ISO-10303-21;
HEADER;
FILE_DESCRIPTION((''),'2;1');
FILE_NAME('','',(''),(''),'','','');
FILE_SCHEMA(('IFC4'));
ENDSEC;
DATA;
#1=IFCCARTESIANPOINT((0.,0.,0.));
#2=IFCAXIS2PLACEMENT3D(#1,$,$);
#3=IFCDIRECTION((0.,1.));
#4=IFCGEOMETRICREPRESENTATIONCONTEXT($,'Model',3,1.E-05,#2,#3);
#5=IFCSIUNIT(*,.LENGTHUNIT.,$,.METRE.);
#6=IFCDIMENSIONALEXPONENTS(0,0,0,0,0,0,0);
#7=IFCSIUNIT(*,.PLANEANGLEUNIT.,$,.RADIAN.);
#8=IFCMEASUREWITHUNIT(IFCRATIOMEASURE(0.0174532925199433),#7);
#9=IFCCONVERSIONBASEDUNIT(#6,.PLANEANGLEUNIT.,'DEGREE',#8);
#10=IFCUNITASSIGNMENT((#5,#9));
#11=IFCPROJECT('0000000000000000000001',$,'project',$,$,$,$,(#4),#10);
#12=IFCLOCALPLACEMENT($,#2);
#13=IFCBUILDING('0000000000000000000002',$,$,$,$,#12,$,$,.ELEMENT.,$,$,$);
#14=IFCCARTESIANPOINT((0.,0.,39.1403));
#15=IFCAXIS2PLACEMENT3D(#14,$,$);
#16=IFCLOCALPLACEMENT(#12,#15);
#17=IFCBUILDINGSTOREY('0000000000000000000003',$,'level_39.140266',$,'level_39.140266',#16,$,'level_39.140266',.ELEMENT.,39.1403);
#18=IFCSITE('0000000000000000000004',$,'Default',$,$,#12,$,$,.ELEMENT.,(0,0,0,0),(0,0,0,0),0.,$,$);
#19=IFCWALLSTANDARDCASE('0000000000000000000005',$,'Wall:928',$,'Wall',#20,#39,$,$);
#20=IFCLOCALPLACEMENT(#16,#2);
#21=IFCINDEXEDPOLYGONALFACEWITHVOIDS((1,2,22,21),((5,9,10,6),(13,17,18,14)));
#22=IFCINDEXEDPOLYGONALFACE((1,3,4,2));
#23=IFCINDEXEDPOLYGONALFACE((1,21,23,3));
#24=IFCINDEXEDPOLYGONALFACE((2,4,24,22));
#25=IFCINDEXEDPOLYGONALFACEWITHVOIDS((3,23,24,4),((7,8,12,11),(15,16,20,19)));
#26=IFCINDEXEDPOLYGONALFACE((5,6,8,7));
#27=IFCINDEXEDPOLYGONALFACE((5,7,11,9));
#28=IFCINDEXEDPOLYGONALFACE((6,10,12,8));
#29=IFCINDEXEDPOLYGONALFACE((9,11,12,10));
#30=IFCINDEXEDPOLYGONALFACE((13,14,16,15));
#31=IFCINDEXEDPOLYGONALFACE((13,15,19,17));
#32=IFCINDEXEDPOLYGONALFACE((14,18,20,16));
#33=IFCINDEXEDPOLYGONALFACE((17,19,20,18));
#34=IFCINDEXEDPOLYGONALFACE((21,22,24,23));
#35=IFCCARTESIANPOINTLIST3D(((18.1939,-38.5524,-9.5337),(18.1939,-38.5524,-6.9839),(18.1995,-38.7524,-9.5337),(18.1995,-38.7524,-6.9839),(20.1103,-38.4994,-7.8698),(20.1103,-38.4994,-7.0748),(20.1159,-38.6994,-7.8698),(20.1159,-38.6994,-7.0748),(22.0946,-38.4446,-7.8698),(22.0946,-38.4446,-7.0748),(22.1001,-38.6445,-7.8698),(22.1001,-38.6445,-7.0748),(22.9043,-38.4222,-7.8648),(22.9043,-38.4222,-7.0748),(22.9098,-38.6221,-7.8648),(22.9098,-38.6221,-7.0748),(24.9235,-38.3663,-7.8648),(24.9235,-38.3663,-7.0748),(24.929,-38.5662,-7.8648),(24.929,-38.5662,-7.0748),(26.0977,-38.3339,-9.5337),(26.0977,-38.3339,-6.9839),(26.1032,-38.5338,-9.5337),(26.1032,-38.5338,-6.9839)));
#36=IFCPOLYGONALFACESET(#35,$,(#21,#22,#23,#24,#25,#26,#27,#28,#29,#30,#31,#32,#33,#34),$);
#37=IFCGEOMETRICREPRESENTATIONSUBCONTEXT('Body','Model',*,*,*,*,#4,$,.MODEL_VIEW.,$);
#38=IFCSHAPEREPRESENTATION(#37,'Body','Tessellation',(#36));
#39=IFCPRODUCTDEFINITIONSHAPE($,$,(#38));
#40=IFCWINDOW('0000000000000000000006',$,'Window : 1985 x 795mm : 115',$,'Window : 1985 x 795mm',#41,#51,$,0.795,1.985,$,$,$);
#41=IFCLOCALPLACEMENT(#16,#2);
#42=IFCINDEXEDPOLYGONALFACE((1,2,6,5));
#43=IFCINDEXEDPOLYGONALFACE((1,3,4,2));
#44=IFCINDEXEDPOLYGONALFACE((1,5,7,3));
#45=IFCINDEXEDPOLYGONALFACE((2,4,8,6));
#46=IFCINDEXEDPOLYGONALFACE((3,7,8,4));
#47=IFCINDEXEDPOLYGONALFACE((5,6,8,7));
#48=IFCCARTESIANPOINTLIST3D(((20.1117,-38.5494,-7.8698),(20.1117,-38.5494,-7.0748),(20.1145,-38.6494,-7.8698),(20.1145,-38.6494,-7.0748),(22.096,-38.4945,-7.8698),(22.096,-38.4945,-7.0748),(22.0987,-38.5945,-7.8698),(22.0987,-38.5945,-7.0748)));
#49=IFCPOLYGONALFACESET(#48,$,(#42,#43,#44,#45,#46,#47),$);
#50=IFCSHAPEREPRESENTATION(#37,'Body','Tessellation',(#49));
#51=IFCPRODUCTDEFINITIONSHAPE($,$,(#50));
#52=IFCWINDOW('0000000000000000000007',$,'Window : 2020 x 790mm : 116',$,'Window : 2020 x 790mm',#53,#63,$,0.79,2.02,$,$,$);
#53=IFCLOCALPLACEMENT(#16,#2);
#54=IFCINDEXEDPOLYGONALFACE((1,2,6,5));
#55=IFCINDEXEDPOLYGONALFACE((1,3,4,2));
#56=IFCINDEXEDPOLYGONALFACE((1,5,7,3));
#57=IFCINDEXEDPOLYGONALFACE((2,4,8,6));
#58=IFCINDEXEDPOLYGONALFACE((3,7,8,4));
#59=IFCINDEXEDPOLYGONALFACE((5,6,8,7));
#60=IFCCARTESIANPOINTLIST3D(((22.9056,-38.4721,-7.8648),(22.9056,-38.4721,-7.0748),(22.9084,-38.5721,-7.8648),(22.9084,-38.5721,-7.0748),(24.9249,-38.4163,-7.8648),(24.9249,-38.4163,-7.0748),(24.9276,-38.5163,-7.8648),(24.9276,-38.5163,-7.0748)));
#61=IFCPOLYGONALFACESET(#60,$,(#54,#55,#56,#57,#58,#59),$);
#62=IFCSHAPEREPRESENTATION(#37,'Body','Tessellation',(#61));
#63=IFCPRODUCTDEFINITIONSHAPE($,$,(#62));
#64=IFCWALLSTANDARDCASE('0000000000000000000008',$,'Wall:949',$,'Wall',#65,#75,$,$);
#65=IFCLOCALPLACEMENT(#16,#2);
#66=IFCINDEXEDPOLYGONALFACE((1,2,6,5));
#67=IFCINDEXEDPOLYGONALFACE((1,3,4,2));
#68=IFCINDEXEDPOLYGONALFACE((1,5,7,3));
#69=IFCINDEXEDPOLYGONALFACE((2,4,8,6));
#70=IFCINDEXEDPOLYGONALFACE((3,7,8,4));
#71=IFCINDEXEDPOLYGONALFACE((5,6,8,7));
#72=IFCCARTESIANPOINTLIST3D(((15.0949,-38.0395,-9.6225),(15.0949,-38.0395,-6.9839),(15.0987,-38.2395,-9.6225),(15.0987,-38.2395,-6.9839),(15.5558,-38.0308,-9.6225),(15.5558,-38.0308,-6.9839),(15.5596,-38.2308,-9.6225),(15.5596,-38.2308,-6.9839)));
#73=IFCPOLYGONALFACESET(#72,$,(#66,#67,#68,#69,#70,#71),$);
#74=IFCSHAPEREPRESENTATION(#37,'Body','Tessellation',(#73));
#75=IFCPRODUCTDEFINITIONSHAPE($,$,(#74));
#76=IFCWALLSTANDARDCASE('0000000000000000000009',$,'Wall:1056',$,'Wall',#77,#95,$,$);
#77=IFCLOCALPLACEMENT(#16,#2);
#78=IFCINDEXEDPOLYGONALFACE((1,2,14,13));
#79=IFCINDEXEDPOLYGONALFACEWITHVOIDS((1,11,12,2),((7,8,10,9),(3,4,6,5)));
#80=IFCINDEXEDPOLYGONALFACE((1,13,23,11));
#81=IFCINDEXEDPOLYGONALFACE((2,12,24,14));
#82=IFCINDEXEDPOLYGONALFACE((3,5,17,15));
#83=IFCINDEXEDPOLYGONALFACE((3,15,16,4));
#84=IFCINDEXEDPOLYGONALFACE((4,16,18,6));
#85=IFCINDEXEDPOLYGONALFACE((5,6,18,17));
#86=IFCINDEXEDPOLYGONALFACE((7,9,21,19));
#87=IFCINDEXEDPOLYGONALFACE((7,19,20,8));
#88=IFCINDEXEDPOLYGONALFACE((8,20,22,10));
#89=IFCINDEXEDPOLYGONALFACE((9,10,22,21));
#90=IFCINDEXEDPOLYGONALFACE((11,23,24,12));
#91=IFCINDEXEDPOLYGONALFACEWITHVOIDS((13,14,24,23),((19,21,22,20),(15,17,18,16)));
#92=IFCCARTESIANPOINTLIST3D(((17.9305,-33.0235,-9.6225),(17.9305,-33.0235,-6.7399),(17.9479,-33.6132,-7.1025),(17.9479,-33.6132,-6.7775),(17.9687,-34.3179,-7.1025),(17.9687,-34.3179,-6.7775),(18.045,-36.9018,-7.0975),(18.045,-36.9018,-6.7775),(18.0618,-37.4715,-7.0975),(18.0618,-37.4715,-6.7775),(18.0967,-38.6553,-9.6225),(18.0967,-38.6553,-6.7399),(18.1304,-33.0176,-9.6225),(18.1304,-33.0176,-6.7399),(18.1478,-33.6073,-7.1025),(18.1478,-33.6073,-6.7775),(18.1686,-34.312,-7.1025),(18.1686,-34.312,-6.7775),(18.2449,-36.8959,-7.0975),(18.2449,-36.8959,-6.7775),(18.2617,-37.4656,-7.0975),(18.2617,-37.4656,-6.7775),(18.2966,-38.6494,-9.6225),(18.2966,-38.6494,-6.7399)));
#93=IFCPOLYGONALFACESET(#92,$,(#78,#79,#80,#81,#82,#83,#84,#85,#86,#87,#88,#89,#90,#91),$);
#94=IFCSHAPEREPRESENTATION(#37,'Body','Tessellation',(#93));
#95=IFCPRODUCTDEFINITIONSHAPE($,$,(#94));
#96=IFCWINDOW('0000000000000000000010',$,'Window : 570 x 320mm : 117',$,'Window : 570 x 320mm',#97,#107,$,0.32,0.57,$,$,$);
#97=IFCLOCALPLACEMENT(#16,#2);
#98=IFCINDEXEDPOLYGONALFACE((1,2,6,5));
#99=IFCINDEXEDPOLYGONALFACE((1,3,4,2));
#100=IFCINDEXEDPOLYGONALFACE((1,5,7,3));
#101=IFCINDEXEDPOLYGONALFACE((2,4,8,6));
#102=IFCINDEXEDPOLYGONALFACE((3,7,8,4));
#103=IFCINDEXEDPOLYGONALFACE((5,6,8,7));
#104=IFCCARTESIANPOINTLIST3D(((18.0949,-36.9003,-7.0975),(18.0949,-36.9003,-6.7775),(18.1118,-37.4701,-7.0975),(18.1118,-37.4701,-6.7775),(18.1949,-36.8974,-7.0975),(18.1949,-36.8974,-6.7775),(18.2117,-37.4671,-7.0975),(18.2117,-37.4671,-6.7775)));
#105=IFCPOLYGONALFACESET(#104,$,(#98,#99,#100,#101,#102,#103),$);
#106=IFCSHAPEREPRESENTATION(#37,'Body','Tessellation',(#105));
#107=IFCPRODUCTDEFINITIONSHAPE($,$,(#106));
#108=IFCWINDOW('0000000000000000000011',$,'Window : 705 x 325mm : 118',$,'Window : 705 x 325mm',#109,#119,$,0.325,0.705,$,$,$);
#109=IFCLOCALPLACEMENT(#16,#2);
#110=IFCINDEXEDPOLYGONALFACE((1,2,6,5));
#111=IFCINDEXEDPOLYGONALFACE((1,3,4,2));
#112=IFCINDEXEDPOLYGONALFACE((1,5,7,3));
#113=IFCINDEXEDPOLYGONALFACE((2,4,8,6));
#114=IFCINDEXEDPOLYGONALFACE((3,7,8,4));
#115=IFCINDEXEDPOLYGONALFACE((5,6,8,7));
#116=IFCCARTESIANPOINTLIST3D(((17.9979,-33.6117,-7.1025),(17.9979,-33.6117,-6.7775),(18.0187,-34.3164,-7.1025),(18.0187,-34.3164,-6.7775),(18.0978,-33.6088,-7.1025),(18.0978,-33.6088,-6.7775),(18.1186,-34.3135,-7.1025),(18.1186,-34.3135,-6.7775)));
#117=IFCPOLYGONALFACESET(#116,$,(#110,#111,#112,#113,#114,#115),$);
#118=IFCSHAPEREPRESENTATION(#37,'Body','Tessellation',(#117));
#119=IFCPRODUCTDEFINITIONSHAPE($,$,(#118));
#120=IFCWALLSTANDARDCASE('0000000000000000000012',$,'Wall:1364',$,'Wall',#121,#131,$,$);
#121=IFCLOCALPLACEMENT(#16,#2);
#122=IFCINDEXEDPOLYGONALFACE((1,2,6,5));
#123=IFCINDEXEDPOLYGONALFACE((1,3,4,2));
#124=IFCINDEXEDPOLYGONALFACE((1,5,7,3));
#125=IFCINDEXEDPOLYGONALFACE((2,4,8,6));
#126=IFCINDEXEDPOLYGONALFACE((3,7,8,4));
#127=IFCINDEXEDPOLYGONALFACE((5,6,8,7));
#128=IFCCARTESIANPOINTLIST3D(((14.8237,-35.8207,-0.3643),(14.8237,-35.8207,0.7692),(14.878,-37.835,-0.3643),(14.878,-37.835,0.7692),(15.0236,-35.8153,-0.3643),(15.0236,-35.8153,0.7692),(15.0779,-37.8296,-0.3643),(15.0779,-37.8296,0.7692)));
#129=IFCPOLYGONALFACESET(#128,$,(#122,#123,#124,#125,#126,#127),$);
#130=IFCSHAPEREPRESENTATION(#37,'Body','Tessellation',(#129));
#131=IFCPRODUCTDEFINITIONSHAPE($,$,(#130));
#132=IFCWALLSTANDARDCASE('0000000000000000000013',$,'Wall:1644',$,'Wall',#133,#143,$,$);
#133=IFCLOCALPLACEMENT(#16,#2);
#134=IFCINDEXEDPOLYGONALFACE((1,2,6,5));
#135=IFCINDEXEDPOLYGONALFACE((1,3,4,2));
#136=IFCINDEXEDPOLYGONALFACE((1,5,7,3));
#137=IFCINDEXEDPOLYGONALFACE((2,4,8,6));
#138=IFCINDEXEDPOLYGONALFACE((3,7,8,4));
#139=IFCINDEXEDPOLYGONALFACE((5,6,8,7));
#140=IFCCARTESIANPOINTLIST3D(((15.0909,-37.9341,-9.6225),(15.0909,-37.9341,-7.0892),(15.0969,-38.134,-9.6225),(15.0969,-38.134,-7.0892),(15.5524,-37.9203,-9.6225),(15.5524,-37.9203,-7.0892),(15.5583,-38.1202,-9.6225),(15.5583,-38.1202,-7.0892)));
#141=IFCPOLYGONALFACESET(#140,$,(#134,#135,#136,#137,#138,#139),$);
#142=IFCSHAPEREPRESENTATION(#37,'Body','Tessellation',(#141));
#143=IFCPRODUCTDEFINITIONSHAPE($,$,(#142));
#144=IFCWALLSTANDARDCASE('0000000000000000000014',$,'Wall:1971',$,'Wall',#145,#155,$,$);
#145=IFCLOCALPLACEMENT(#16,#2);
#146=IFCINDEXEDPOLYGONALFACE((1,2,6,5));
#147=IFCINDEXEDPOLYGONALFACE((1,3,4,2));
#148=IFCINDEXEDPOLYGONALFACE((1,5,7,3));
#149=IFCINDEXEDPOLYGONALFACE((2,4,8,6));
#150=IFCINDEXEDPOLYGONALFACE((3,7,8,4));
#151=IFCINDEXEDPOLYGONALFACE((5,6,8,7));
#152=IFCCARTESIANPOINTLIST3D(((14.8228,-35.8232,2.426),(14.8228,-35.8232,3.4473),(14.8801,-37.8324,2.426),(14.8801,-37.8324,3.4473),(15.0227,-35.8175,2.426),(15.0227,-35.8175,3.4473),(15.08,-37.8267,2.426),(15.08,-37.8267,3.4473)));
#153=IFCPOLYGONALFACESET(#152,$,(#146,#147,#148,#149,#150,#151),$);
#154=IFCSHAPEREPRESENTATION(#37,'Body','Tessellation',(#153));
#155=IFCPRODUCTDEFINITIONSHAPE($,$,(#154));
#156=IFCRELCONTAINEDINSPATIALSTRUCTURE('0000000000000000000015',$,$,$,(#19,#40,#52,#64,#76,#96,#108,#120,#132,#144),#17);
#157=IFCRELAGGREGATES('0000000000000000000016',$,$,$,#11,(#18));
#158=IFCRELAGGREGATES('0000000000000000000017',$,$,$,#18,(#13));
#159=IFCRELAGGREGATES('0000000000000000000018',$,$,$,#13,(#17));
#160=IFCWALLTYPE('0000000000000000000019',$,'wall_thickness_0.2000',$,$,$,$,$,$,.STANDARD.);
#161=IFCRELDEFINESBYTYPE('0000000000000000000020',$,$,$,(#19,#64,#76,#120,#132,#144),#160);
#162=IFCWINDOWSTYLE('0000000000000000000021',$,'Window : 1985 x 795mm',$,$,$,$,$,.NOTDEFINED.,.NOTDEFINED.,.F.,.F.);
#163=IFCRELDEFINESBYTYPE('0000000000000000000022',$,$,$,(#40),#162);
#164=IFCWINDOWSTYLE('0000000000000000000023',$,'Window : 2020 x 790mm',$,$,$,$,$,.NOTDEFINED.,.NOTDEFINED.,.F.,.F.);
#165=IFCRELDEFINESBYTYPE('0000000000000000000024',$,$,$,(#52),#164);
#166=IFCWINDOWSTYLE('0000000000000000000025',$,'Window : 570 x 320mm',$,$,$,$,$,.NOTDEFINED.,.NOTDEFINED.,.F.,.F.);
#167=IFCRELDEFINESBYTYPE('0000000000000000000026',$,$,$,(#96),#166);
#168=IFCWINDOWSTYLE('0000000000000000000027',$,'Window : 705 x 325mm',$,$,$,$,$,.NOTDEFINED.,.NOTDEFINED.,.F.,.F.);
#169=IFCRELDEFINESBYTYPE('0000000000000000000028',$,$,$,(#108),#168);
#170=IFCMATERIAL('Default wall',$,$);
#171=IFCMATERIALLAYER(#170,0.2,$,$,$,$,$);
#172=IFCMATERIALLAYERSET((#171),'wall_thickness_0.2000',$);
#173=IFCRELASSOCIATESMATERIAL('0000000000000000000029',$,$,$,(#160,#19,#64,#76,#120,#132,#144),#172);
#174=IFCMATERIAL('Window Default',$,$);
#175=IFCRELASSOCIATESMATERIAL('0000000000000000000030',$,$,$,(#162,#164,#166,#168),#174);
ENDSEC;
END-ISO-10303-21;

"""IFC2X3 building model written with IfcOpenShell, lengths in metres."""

from ifc_helpers import new_model, entity, si_unit, converted_unit, direction, frame, frame_2d, origin, origin_2d_with_axis, place, context, subcontext, project, spatial, polyline, rectangle, outline, extrude, source, transform, mapped, material, layer, layer_set, layer_usage, type_object, type_shapes, element, fill, save


model = new_model("IFC2X3")

# Units and contexts
model_context = context("Model", 3, precision=1e-05, world=origin(), true_north=direction((0.0, 1.0)))
body_context = subcontext(model_context, "Body", "Model", "MODEL_VIEW")
ifc_project = project(units=[si_unit("LENGTHUNIT", "METRE"), converted_unit("PLANEANGLEUNIT", "DEGREE", entity("IfcRatioMeasure", 0.0174532925199433), si_unit("PLANEANGLEUNIT", "RADIAN"), dimensions=[0, 0, 0, 0, 0, 0, 0])], contexts=[model_context])

# Site, building, storey
placement_1 = place(None, origin())
site = spatial("IfcSite", under=ifc_project, at=placement_1, Name="Default", CompositionType="ELEMENT", RefLatitude=(0, 0, 0, 0), RefLongitude=(0, 0, 0, 0), RefElevation=0.0)
building = spatial("IfcBuilding", under=site, at=placement_1, CompositionType="ELEMENT")
storey_placement = place(placement_1, frame((0.0, 0.0, 39.1403)))
storey = spatial("IfcBuildingStorey", under=building, at=storey_placement, Name="level_39.140266", ObjectType="level_39.140266", LongName="level_39.140266", CompositionType="ELEMENT", Elevation=39.1403)

# Shared definitions
ifc_material_1 = material(Name="Default wall")
ifc_layer = layer(ifc_material_1, 0.2)
ifc_layer_set = layer_set([ifc_layer], Name="wall_thickness_0.2000")
ifc_layer_usage = layer_usage(ifc_layer_set, "AXIS2", "POSITIVE", -0.1)
wall_type = type_object("IfcWallType", Name="wall_thickness_0.2000", PredefinedType="STANDARD", material=ifc_layer_set)

# Wall, openings, windows
placement_2 = place(placement_1, frame((0.0, 0.0, 29.6066)))
wall_1_placement = place(placement_2, frame((18.1967, -38.6524, 0.0), z_axis=(0.0, 0.0, 1.0), x_axis=(0.999618, 0.027644, 0.0)))
wall_1 = element("IfcWallStandardCase", 1, at=wall_1_placement, inside=storey, type_object=wall_type, material=ifc_layer_usage, Name="Wall:928", ObjectType="Wall", context=body_context, shape_type="SweptSolid", body=[
    extrude(outline(polyline([(7.9068, -0.1), (7.9068, 0.1), (0.0, 0.1), (0.0, -0.1), (7.9068, -0.1)])), origin(), (0.0, 0.0, 1.0), 2.5498),
])
opening_1_placement = place(wall_1_placement, frame((1.9171, -0.1, 1.6639)))
opening_1 = element("IfcOpeningElement", 2, at=opening_1_placement, cuts=wall_1, ObjectType="Opening", context=body_context, shape_type="SweptSolid", body=[
    extrude(rectangle(XDim=1.985, YDim=0.795, at=frame_2d((0.3975, 0.9925), x_axis=(0.0, 1.0))), frame((0.0, 0.0, 0.0), z_axis=(0.0, 1.0, 0.0), x_axis=(0.0, 0.0, 1.0)), (0.0, 0.0, 1.0), 0.2),
])
opening_2_placement = place(wall_1_placement, frame((4.7121, -0.1, 1.6689)))
opening_2 = element("IfcOpeningElement", 3, at=opening_2_placement, cuts=wall_1, ObjectType="Opening", context=body_context, shape_type="SweptSolid", body=[
    extrude(rectangle(XDim=2.02, YDim=0.79, at=frame_2d((0.395, 1.01), x_axis=(0.0, 1.0))), frame((0.0, 0.0, 0.0), z_axis=(0.0, 1.0, 0.0), x_axis=(0.0, 0.0, 1.0)), (0.0, 0.0, 1.0), 0.2),
])
ifc_material_2 = material(Name="Window Default")
window_style_1 = type_object("IfcWindowStyle", Name="Window : 1985 x 795mm", ConstructionType="NOTDEFINED", OperationType="NOTDEFINED", ParameterTakesPrecedence=False, Sizeable=False, material=ifc_material_2)
shared_shape_1 = source(origin(), body_context, "Body", "SweptSolid", [
    extrude(rectangle(XDim=0.1, YDim=1.985, at=origin_2d_with_axis()), frame((0.9925, 0.1, 0.0), z_axis=(0.0, 0.0, 1.0), x_axis=(0.0, 1.0, 0.0)), (0.0, 0.0, 1.0), 0.795),
])
type_shapes(window_style_1, [shared_shape_1])
window_1_placement = place(opening_1_placement, origin())
window_1 = element("IfcWindow", 4, at=window_1_placement, inside=storey, type_object=window_style_1, Name="Window : 1985 x 795mm : 115", ObjectType="Window : 1985 x 795mm", OverallHeight=0.795, OverallWidth=1.985, context=body_context, shape_type="MappedRepresentation", body=[
    mapped(shared_shape_1, transform((0.0, 0.0, 0.0), scale=1.0)),
])
fill(opening_1, window_1)
window_style_2 = type_object("IfcWindowStyle", Name="Window : 2020 x 790mm", ConstructionType="NOTDEFINED", OperationType="NOTDEFINED", ParameterTakesPrecedence=False, Sizeable=False, material=ifc_material_2)
shared_shape_2 = source(origin(), body_context, "Body", "SweptSolid", [
    extrude(rectangle(XDim=0.1, YDim=2.02, at=origin_2d_with_axis()), frame((1.01, 0.1, 0.0), z_axis=(0.0, 0.0, 1.0), x_axis=(0.0, 1.0, 0.0)), (0.0, 0.0, 1.0), 0.79),
])
type_shapes(window_style_2, [shared_shape_2])
window_2_placement = place(opening_2_placement, origin())
window_2 = element("IfcWindow", 5, at=window_2_placement, inside=storey, type_object=window_style_2, Name="Window : 2020 x 790mm : 116", ObjectType="Window : 2020 x 790mm", OverallHeight=0.79, OverallWidth=2.02, context=body_context, shape_type="MappedRepresentation", body=[
    mapped(shared_shape_2, transform((0.0, 0.0, 0.0), scale=1.0)),
])
fill(opening_2, window_2)

# Wall
placement_3 = place(placement_1, frame((0.0, 0.0, 29.5178)))
wall_2_placement = place(placement_3, frame((15.5577, -38.1308, 0.0), z_axis=(0.0, 0.0, 1.0), x_axis=(-0.99982, -0.018969, 0.0)))
element("IfcWallStandardCase", 6, at=wall_2_placement, inside=storey, type_object=wall_type, material=ifc_layer_usage, Name="Wall:949", ObjectType="Wall", context=body_context, shape_type="SweptSolid", body=[
    extrude(outline(polyline([(0.4609, -0.1), (0.4609, 0.1), (0.0, 0.1), (0.0, -0.1), (0.4609, -0.1)])), origin(), (0.0, 0.0, 1.0), 2.6386),
])

# Wall, openings, windows
placement_4 = place(placement_1, frame((0.0, 0.0, 29.5178)))
wall_3_placement = place(placement_4, frame((18.1967, -38.6524, 0.0), z_axis=(0.0, 0.0, 1.0), x_axis=(-0.029505, 0.999565, 0.0)))
wall_3 = element("IfcWallStandardCase", 7, at=wall_3_placement, inside=storey, type_object=wall_type, material=ifc_layer_usage, Name="Wall:1056", ObjectType="Wall", context=body_context, shape_type="SweptSolid", body=[
    extrude(outline(polyline([(5.6343, -0.1), (5.6343, 0.1), (0.0, 0.1), (0.0, -0.1), (5.6343, -0.1)])), origin(), (0.0, 0.0, 1.0), 2.8826),
])
opening_3_placement = place(wall_3_placement, frame((1.1843, -0.1, 2.525)))
opening_3 = element("IfcOpeningElement", 8, at=opening_3_placement, cuts=wall_3, ObjectType="Opening", context=body_context, shape_type="SweptSolid", body=[
    extrude(rectangle(XDim=0.57, YDim=0.32, at=frame_2d((0.16, 0.285), x_axis=(0.0, 1.0))), frame((0.0, 0.0, 0.0), z_axis=(0.0, 1.0, 0.0), x_axis=(0.0, 0.0, 1.0)), (0.0, 0.0, 1.0), 0.2),
])
opening_4_placement = place(wall_3_placement, frame((4.3393, -0.1, 2.52)))
opening_4 = element("IfcOpeningElement", 9, at=opening_4_placement, cuts=wall_3, ObjectType="Opening", context=body_context, shape_type="SweptSolid", body=[
    extrude(rectangle(XDim=0.705, YDim=0.325, at=frame_2d((0.1625, 0.3525), x_axis=(0.0, 1.0))), frame((0.0, 0.0, 0.0), z_axis=(0.0, 1.0, 0.0), x_axis=(0.0, 0.0, 1.0)), (0.0, 0.0, 1.0), 0.2),
])
window_style_3 = type_object("IfcWindowStyle", Name="Window : 570 x 320mm", ConstructionType="NOTDEFINED", OperationType="NOTDEFINED", ParameterTakesPrecedence=False, Sizeable=False, material=ifc_material_2)
shared_shape_3 = source(origin(), body_context, "Body", "SweptSolid", [
    extrude(rectangle(XDim=0.1, YDim=0.57, at=origin_2d_with_axis()), frame((0.285, 0.1, 0.0), z_axis=(0.0, 0.0, 1.0), x_axis=(0.0, 1.0, 0.0)), (0.0, 0.0, 1.0), 0.32),
])
type_shapes(window_style_3, [shared_shape_3])
window_3_placement = place(opening_3_placement, origin())
window_3 = element("IfcWindow", 10, at=window_3_placement, inside=storey, type_object=window_style_3, Name="Window : 570 x 320mm : 117", ObjectType="Window : 570 x 320mm", OverallHeight=0.32, OverallWidth=0.57, context=body_context, shape_type="MappedRepresentation", body=[
    mapped(shared_shape_3, transform((0.0, 0.0, 0.0), scale=1.0)),
])
fill(opening_3, window_3)
window_style_4 = type_object("IfcWindowStyle", Name="Window : 705 x 325mm", ConstructionType="NOTDEFINED", OperationType="NOTDEFINED", ParameterTakesPrecedence=False, Sizeable=False, material=ifc_material_2)
shared_shape_4 = source(origin(), body_context, "Body", "SweptSolid", [
    extrude(rectangle(XDim=0.1, YDim=0.705, at=origin_2d_with_axis()), frame((0.3525, 0.1, 0.0), z_axis=(0.0, 0.0, 1.0), x_axis=(0.0, 1.0, 0.0)), (0.0, 0.0, 1.0), 0.325),
])
type_shapes(window_style_4, [shared_shape_4])
window_4_placement = place(opening_4_placement, origin())
window_4 = element("IfcWindow", 11, at=window_4_placement, inside=storey, type_object=window_style_4, Name="Window : 705 x 325mm : 118", ObjectType="Window : 705 x 325mm", OverallHeight=0.325, OverallWidth=0.705, context=body_context, shape_type="MappedRepresentation", body=[
    mapped(shared_shape_4, transform((0.0, 0.0, 0.0), scale=1.0)),
])
fill(opening_4, window_4)

# Walls
placement_5 = place(placement_1, frame((0.0, 0.0, 38.776)))
wall_4_placement = place(placement_5, frame((14.978, -37.8323, 0.0), z_axis=(0.0, 0.0, 1.0), x_axis=(-0.026945, 0.999637, 0.0)))
element("IfcWallStandardCase", 12, at=wall_4_placement, inside=storey, type_object=wall_type, material=ifc_layer_usage, Name="Wall:1364", ObjectType="Wall", context=body_context, shape_type="SweptSolid", body=[
    extrude(outline(polyline([(2.015, -0.1), (2.015, 0.1), (0.0, 0.1), (0.0, -0.1), (2.015, -0.1)])), origin(), (0.0, 0.0, 1.0), 1.1335),
])
placement_6 = place(placement_1, frame((0.0, 0.0, 29.5178)))
wall_5_placement = place(placement_6, frame((15.5554, -38.0203, 0.0), z_axis=(0.0, 0.0, 1.0), x_axis=(-0.999554, -0.02986, 0.0)))
element("IfcWallStandardCase", 13, at=wall_5_placement, inside=storey, type_object=wall_type, material=ifc_layer_usage, Name="Wall:1644", ObjectType="Wall", context=body_context, shape_type="SweptSolid", body=[
    extrude(outline(polyline([(0.4617, -0.1), (0.4617, 0.1), (0.0, 0.1), (0.0, -0.1), (0.4617, -0.1)])), origin(), (0.0, 0.0, 1.0), 2.5333),
])
placement_7 = place(placement_1, frame((0.0, 0.0, 41.5663)))
wall_6_placement = place(placement_7, frame((14.9801, -37.8296, 0.0), z_axis=(0.0, 0.0, 1.0), x_axis=(-0.028504, 0.999594, 0.0)))
element("IfcWallStandardCase", 14, at=wall_6_placement, inside=storey, type_object=wall_type, material=ifc_layer_usage, Name="Wall:1971", ObjectType="Wall", context=body_context, shape_type="SweptSolid", body=[
    extrude(outline(polyline([(2.01, -0.1), (2.01, 0.1), (0.0, 0.1), (0.0, -0.1), (2.01, -0.1)])), origin(), (0.0, 0.0, 1.0), 1.0213),
])

save(model, "model.ifc")
